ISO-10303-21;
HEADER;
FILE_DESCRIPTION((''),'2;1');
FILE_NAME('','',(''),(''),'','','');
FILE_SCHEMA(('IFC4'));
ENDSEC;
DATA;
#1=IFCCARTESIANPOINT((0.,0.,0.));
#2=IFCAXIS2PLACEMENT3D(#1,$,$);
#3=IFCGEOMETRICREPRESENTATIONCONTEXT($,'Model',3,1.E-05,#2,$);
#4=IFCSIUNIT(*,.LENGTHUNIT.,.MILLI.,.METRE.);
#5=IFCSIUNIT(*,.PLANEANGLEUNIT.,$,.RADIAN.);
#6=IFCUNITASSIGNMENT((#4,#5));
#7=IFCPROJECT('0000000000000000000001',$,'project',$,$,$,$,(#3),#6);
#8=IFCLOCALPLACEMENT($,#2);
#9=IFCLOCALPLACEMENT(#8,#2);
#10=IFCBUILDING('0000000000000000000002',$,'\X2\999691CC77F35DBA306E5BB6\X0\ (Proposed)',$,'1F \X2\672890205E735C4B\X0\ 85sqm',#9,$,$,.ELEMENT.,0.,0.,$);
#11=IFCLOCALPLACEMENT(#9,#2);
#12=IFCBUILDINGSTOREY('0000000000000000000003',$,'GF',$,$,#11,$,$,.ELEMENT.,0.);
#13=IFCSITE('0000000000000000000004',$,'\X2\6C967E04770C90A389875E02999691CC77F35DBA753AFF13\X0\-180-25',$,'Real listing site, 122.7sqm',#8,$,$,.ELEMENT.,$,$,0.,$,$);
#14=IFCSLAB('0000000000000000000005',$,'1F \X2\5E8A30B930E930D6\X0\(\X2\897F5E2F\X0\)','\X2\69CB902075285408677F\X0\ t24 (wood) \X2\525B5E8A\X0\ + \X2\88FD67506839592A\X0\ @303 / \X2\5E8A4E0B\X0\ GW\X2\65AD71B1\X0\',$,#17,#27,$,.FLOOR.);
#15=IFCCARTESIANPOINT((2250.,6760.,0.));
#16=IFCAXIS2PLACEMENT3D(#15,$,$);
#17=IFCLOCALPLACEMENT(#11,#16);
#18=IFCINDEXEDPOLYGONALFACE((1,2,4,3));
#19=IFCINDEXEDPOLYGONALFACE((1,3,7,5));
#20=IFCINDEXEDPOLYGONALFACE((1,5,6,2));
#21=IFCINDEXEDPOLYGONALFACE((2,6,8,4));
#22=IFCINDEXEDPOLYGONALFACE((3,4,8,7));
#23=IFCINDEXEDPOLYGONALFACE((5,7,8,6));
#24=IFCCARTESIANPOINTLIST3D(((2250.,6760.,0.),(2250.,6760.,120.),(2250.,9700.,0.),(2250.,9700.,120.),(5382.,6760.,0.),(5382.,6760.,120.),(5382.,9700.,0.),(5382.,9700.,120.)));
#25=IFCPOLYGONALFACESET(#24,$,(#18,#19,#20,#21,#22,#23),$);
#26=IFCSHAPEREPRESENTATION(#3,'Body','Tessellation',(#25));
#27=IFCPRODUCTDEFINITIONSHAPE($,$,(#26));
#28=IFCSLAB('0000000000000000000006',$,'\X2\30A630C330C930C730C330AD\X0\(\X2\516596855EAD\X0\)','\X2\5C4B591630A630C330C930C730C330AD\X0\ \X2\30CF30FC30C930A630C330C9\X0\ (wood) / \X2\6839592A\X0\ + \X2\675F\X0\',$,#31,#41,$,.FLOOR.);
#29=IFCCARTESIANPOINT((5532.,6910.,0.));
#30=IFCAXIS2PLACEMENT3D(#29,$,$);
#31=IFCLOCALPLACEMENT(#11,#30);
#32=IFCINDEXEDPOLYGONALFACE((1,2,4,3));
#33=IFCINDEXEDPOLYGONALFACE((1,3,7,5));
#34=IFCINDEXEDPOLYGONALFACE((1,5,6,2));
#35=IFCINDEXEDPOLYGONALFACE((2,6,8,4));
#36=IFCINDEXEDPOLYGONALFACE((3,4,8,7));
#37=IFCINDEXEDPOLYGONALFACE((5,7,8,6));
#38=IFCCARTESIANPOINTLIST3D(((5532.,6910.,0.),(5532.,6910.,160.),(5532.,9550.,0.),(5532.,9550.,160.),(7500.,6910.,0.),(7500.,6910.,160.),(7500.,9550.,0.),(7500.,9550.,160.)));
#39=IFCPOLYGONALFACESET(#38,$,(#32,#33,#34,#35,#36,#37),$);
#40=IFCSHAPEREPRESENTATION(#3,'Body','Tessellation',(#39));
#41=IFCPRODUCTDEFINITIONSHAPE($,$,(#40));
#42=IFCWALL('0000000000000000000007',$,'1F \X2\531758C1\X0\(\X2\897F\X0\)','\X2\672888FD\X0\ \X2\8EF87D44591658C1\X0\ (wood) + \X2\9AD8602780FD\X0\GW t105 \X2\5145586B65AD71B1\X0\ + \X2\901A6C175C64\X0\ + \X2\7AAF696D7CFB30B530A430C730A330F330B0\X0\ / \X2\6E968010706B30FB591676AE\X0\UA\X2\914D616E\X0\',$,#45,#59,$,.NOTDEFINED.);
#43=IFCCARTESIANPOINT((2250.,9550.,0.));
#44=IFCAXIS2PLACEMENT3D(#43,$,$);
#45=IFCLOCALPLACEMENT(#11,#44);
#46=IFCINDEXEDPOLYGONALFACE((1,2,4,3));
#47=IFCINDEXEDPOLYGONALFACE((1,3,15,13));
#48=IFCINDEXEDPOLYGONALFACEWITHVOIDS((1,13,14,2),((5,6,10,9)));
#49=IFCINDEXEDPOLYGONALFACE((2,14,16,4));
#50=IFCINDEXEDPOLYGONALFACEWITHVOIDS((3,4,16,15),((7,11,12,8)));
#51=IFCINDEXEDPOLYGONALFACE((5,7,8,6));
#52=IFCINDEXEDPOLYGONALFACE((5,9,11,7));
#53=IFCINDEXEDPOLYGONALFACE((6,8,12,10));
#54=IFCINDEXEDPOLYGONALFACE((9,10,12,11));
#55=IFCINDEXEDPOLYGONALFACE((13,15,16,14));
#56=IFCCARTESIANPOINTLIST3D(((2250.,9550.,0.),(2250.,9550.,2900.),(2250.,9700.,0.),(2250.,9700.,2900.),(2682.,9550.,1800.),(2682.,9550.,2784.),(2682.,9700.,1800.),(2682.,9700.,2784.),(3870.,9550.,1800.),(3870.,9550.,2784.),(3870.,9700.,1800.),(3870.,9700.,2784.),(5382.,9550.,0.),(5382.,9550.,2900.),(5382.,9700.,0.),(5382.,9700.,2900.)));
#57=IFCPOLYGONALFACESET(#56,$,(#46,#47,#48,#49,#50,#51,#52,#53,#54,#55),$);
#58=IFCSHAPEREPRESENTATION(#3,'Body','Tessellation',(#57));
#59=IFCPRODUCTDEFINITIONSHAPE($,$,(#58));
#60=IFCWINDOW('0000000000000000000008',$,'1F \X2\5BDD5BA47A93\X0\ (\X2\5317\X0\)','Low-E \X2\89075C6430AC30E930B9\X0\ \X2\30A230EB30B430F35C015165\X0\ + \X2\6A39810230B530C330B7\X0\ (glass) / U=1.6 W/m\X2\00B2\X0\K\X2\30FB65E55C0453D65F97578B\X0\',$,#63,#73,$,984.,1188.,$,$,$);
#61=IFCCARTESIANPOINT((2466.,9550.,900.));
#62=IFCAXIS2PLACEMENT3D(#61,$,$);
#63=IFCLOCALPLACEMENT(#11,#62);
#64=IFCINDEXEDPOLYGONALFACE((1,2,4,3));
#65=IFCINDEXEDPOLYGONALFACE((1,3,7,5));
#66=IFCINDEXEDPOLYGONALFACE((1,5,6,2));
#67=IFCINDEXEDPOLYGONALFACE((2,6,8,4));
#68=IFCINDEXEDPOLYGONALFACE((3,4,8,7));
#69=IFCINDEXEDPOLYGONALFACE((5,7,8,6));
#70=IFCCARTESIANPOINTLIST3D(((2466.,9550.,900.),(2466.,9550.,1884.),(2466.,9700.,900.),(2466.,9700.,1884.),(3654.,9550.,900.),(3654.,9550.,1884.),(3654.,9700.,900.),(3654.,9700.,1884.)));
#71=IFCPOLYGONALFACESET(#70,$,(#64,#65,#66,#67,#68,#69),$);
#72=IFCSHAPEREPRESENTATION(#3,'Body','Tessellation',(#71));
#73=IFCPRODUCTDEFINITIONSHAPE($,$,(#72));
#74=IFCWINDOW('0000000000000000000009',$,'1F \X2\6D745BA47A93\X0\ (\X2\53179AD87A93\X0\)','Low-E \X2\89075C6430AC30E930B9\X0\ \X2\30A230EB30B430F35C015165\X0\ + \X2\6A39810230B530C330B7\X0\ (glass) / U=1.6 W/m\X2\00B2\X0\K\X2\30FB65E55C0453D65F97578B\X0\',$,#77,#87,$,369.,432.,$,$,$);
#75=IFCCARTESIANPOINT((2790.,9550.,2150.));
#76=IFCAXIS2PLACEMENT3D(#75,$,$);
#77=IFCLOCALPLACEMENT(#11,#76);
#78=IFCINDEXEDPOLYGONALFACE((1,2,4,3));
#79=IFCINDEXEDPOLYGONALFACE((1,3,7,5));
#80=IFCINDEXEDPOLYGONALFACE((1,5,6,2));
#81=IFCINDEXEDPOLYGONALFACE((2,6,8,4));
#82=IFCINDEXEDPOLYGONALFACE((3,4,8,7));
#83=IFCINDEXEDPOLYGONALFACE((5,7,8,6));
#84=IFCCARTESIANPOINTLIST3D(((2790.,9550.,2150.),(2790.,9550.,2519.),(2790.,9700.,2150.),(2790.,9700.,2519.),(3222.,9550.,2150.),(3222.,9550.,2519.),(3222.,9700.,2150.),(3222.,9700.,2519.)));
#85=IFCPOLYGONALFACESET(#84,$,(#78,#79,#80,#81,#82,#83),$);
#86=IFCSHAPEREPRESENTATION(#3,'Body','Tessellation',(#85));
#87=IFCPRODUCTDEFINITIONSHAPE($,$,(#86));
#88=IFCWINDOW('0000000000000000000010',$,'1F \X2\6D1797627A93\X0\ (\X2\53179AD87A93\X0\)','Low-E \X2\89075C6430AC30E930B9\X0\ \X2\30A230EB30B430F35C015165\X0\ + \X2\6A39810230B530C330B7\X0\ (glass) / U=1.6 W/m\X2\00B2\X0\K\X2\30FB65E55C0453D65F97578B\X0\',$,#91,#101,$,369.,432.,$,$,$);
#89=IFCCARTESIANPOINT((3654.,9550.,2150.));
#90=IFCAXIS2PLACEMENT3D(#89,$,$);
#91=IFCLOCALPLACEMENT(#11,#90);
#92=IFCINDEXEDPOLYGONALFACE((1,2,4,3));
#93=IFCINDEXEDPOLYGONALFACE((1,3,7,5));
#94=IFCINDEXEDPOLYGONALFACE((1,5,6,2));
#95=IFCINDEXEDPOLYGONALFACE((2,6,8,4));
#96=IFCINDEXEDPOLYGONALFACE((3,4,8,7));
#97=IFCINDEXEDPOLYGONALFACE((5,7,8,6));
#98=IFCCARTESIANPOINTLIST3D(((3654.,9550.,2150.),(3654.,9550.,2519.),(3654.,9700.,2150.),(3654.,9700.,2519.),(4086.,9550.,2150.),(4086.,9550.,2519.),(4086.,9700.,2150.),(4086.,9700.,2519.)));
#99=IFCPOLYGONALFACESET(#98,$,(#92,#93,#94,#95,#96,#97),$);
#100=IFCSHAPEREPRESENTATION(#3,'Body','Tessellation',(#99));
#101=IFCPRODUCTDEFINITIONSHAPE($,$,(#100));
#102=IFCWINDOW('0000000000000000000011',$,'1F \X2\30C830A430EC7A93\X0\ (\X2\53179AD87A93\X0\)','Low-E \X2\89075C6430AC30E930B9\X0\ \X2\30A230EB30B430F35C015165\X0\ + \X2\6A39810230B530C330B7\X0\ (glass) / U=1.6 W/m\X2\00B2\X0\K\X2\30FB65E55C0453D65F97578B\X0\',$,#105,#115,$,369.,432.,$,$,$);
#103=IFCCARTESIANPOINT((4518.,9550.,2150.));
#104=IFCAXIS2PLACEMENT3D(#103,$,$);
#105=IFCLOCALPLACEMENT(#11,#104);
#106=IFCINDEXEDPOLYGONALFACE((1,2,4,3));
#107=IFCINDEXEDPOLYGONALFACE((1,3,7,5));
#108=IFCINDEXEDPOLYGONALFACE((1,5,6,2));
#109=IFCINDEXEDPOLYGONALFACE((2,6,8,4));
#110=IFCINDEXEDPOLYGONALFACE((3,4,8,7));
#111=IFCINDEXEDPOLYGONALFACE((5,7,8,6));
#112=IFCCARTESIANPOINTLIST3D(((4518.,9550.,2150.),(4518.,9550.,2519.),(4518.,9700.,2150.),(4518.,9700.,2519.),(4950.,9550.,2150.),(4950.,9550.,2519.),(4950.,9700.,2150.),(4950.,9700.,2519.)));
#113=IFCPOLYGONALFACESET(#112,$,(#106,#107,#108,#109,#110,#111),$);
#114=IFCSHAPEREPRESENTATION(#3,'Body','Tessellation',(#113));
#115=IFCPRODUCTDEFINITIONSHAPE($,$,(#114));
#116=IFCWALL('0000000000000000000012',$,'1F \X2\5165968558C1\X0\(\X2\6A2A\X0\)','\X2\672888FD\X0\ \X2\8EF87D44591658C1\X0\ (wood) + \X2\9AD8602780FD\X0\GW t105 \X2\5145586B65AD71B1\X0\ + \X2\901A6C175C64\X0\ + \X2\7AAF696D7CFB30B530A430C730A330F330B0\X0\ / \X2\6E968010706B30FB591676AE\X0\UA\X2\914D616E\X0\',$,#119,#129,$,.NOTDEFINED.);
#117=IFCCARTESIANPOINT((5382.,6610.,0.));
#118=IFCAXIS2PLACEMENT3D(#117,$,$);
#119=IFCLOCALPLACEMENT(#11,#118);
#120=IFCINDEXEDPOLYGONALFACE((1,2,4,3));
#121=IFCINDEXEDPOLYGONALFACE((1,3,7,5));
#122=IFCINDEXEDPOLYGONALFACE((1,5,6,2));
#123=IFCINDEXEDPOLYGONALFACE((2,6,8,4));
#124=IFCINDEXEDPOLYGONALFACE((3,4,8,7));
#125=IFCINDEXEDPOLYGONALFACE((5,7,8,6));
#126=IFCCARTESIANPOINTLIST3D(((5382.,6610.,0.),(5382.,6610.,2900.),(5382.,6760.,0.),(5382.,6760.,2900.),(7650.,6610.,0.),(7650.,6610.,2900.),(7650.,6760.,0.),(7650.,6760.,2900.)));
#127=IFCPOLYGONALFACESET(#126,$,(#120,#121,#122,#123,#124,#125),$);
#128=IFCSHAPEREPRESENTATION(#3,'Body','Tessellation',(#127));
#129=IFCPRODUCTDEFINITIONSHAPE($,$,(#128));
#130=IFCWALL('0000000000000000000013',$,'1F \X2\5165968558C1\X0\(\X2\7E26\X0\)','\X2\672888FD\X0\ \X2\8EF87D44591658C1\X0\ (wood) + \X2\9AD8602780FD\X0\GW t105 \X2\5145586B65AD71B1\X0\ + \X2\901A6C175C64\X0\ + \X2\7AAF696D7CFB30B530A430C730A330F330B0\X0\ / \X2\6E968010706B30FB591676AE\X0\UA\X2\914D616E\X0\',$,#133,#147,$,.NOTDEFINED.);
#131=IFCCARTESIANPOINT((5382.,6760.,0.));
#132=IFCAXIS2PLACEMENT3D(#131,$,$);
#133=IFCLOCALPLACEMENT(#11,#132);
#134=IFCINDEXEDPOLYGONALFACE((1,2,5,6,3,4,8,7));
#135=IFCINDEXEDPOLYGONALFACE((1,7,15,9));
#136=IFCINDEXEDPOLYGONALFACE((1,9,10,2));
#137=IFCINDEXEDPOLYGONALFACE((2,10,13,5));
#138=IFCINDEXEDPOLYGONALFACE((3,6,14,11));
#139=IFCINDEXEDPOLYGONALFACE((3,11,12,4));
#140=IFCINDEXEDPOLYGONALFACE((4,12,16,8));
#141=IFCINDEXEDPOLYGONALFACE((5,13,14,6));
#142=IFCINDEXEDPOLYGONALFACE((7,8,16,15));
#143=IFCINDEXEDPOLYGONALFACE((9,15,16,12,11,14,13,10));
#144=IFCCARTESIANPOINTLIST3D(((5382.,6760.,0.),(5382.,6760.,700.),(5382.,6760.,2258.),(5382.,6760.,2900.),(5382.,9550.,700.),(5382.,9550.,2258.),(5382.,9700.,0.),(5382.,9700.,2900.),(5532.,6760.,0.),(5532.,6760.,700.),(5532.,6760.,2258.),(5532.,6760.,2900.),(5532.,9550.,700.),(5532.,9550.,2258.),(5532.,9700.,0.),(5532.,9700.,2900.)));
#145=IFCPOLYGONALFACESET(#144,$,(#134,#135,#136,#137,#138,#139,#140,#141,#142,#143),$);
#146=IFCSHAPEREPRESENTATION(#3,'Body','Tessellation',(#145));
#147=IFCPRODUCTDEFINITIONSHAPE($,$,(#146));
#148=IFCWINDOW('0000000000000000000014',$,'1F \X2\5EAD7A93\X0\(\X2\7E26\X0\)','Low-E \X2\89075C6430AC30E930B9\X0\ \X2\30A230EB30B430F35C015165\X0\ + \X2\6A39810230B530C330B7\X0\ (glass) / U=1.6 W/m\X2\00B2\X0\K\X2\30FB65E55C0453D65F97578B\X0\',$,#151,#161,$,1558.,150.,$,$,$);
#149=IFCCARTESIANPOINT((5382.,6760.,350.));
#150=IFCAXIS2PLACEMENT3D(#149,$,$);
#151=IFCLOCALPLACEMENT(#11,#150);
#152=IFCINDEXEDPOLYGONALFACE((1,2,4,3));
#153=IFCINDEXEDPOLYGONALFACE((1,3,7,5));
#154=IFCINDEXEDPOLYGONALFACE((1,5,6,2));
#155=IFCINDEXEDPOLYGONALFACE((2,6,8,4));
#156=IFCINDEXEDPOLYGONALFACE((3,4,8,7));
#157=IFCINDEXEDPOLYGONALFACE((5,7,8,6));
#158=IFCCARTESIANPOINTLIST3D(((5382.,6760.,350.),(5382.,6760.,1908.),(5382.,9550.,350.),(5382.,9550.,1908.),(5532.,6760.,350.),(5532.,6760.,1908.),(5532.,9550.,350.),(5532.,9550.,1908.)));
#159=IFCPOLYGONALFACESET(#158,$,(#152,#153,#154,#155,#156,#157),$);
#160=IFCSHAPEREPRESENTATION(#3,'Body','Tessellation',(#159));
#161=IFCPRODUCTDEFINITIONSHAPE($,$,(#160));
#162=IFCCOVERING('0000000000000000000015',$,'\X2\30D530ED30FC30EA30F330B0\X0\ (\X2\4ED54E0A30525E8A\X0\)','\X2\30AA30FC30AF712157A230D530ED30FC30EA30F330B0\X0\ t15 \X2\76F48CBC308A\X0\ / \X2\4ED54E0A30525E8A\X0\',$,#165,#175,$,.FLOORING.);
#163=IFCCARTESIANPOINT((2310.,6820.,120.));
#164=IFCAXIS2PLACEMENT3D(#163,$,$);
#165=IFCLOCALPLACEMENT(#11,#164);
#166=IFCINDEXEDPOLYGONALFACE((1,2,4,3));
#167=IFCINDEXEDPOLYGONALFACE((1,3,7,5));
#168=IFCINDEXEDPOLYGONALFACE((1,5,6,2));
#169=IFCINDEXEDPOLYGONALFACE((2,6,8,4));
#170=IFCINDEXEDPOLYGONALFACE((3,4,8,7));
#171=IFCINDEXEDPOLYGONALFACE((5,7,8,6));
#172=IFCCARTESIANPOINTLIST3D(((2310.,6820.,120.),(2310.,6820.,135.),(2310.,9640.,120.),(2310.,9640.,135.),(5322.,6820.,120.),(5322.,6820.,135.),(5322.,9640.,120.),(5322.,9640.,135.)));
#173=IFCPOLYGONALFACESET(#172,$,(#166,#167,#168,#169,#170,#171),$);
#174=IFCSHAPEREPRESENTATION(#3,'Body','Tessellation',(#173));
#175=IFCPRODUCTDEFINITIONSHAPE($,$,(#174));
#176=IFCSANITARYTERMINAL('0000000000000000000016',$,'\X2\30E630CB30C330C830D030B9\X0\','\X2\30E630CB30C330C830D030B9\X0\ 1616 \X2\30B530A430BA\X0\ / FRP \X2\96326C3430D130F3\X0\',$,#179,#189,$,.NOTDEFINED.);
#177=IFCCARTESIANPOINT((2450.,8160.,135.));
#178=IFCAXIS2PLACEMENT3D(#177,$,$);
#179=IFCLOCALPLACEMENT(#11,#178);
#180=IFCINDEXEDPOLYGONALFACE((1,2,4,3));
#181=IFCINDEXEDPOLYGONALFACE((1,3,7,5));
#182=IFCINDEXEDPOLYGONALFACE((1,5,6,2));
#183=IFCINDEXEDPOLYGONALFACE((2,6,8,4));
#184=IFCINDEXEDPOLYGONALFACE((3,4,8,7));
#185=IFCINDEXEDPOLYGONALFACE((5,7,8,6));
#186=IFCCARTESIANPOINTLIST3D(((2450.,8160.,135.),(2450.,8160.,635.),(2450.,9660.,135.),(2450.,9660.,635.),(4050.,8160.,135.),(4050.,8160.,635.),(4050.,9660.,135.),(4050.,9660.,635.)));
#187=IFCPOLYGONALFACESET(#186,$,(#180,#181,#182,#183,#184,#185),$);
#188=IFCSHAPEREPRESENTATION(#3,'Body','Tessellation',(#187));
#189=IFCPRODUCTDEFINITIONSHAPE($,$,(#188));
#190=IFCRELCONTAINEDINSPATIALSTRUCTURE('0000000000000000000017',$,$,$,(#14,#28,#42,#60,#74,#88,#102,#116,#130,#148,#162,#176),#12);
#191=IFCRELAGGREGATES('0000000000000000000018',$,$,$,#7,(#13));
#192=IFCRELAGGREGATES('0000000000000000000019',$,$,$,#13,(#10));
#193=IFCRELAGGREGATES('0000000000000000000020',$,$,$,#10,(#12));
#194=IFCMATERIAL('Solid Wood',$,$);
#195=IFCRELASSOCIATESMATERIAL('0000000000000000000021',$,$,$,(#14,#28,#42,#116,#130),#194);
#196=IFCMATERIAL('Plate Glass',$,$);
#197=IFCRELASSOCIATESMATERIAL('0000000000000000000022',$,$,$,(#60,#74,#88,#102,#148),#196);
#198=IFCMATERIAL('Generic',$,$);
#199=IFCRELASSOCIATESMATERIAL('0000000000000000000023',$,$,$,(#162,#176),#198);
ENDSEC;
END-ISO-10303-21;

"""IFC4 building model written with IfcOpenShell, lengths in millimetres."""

from ifc_helpers import new_model, si_unit, frame, frame_2d, origin, place, context, project, spatial, rectangle, extrude, material, element, fill, save


model = new_model("IFC4")

# Units and contexts
model_context = context("Model", 3, precision=1e-05, world=origin())
ifc_project = project(units=[si_unit("LENGTHUNIT", "METRE", prefix="MILLI"), si_unit("PLANEANGLEUNIT", "RADIAN")], contexts=[model_context])

# Site, building, storey
site_placement = place(None, origin())
site = spatial("IfcSite", under=ifc_project, at=site_placement, Name="沖縄県那覇市首里石嶺町３-180-25", ObjectType="Real listing site, 122.7sqm", CompositionType="ELEMENT", RefElevation=0.0)
building_placement = place(site_placement, origin())
building = spatial("IfcBuilding", under=site, at=building_placement, Name="首里石嶺の家 (Proposed)", ObjectType="1F 木造平屋 85sqm", CompositionType="ELEMENT", ElevationOfRefHeight=0.0, ElevationOfTerrain=0.0)
storey_placement = place(building_placement, origin())
storey = spatial("IfcBuildingStorey", under=building, at=storey_placement, Name="GF", CompositionType="ELEMENT", Elevation=0.0)

# Slabs
ifc_material_1 = material(Name="Solid Wood")
slab_1_placement = place(storey_placement, frame((2250.0, 6760.0, 0.0)))
element("IfcSlab", 1, at=slab_1_placement, inside=storey, material=ifc_material_1, Name="1F 床スラブ(西帯)", Description="構造用合板 t24 (wood) 剛床 + 製材根太 @303 / 床下 GW断熱", PredefinedType="FLOOR", context=model_context, shape_type="SweptSolid", body=[
    extrude(rectangle(XDim=3132.0, YDim=2940.0, at=frame_2d((1566.0, 1470.0))), frame((2250.0, 6760.0, 0.0)), (0.0, 0.0, 1.0), 120.0),
])
slab_2_placement = place(storey_placement, frame((5532.0, 6910.0, 0.0)))
element("IfcSlab", 2, at=slab_2_placement, inside=storey, material=ifc_material_1, Name="ウッドデッキ(入隅庭)", Description="屋外ウッドデッキ ハードウッド (wood) / 根太 + 束", PredefinedType="FLOOR", context=model_context, shape_type="SweptSolid", body=[
    extrude(rectangle(XDim=1968.0, YDim=2640.0, at=frame_2d((984.0, 1320.0))), frame((5532.0, 6910.0, 0.0)), (0.0, 0.0, 1.0), 160.0),
])

# Wall, openings, windows
wall_1_placement = place(storey_placement, frame((2250.0, 9550.0, 0.0)))
wall_1 = element("IfcWall", 3, at=wall_1_placement, inside=storey, material=ifc_material_1, Name="1F 北壁(西)", Description="木製 軸組外壁 (wood) + 高性能GW t105 充填断熱 + 通気層 + 窯業系サイディング / 準耐火・外皮UA配慮", PredefinedType="NOTDEFINED", context=model_context, shape_type="SweptSolid", body=[
    extrude(rectangle(XDim=3132.0, YDim=150.0, at=frame_2d((1566.0, 75.0))), frame((2250.0, 9550.0, 0.0)), (0.0, 0.0, 1.0), 2900.0),
])
opening_1_placement = place(storey_placement, frame((2466.0, 9550.0, 900.0)))
opening_1 = element("IfcOpeningElement", 4, at=opening_1_placement, cuts=wall_1, PredefinedType="NOTDEFINED", context=model_context, shape_type="SweptSolid", body=[
    extrude(rectangle(XDim=1188.0, YDim=150.0, at=frame_2d((594.0, 75.0))), frame((2466.0, 9550.0, 900.0)), (0.0, 0.0, 1.0), 984.0),
])
opening_2_placement = place(storey_placement, frame((2790.0, 9550.0, 2150.0)))
opening_2 = element("IfcOpeningElement", 5, at=opening_2_placement, cuts=wall_1, PredefinedType="NOTDEFINED", context=model_context, shape_type="SweptSolid", body=[
    extrude(rectangle(XDim=432.0, YDim=150.0, at=frame_2d((216.0, 75.0))), frame((2790.0, 9550.0, 2150.0)), (0.0, 0.0, 1.0), 369.0),
])
opening_3_placement = place(storey_placement, frame((3654.0, 9550.0, 2150.0)))
opening_3 = element("IfcOpeningElement", 6, at=opening_3_placement, cuts=wall_1, PredefinedType="NOTDEFINED", context=model_context, shape_type="SweptSolid", body=[
    extrude(rectangle(XDim=432.0, YDim=150.0, at=frame_2d((216.0, 75.0))), frame((3654.0, 9550.0, 2150.0)), (0.0, 0.0, 1.0), 369.0),
])
opening_4_placement = place(storey_placement, frame((4518.0, 9550.0, 2150.0)))
opening_4 = element("IfcOpeningElement", 7, at=opening_4_placement, cuts=wall_1, PredefinedType="NOTDEFINED", context=model_context, shape_type="SweptSolid", body=[
    extrude(rectangle(XDim=432.0, YDim=150.0, at=frame_2d((216.0, 75.0))), frame((4518.0, 9550.0, 2150.0)), (0.0, 0.0, 1.0), 369.0),
])
ifc_material_2 = material(Name="Plate Glass")
window_1_placement = place(storey_placement, frame((2466.0, 9550.0, 900.0)))
window_1 = element("IfcWindow", 8, at=window_1_placement, inside=storey, material=ifc_material_2, Name="1F 寝室窓 (北)", Description="Low-E 複層ガラス アルゴン封入 + 樹脂サッシ (glass) / U=1.6 W/m²K・日射取得型", OverallHeight=984.0, OverallWidth=1188.0, context=model_context, shape_type="SweptSolid", body=[
    extrude(rectangle(XDim=1188.0, YDim=150.0, at=frame_2d((594.0, 75.0))), frame((2466.0, 9550.0, 900.0)), (0.0, 0.0, 1.0), 984.0),
])
fill(opening_1, window_1)
window_2_placement = place(storey_placement, frame((2790.0, 9550.0, 2150.0)))
window_2 = element("IfcWindow", 9, at=window_2_placement, inside=storey, material=ifc_material_2, Name="1F 浴室窓 (北高窓)", Description="Low-E 複層ガラス アルゴン封入 + 樹脂サッシ (glass) / U=1.6 W/m²K・日射取得型", OverallHeight=369.0, OverallWidth=432.0, context=model_context, shape_type="SweptSolid", body=[
    extrude(rectangle(XDim=432.0, YDim=150.0, at=frame_2d((216.0, 75.0))), frame((2790.0, 9550.0, 2150.0)), (0.0, 0.0, 1.0), 369.0),
])
fill(opening_2, window_2)
window_3_placement = place(storey_placement, frame((3654.0, 9550.0, 2150.0)))
window_3 = element("IfcWindow", 10, at=window_3_placement, inside=storey, material=ifc_material_2, Name="1F 洗面窓 (北高窓)", Description="Low-E 複層ガラス アルゴン封入 + 樹脂サッシ (glass) / U=1.6 W/m²K・日射取得型", OverallHeight=369.0, OverallWidth=432.0, context=model_context, shape_type="SweptSolid", body=[
    extrude(rectangle(XDim=432.0, YDim=150.0, at=frame_2d((216.0, 75.0))), frame((3654.0, 9550.0, 2150.0)), (0.0, 0.0, 1.0), 369.0),
])
fill(opening_3, window_3)
window_4_placement = place(storey_placement, frame((4518.0, 9550.0, 2150.0)))
window_4 = element("IfcWindow", 11, at=window_4_placement, inside=storey, material=ifc_material_2, Name="1F トイレ窓 (北高窓)", Description="Low-E 複層ガラス アルゴン封入 + 樹脂サッシ (glass) / U=1.6 W/m²K・日射取得型", OverallHeight=369.0, OverallWidth=432.0, context=model_context, shape_type="SweptSolid", body=[
    extrude(rectangle(XDim=432.0, YDim=150.0, at=frame_2d((216.0, 75.0))), frame((4518.0, 9550.0, 2150.0)), (0.0, 0.0, 1.0), 369.0),
])
fill(opening_4, window_4)

# Wall
wall_2_placement = place(storey_placement, frame((5382.0, 6610.0, 0.0)))
element("IfcWall", 12, at=wall_2_placement, inside=storey, material=ifc_material_1, Name="1F 入隅壁(横)", Description="木製 軸組外壁 (wood) + 高性能GW t105 充填断熱 + 通気層 + 窯業系サイディング / 準耐火・外皮UA配慮", PredefinedType="NOTDEFINED", context=model_context, shape_type="SweptSolid", body=[
    extrude(rectangle(XDim=2268.0, YDim=150.0, at=frame_2d((1134.0, 75.0))), frame((5382.0, 6610.0, 0.0)), (0.0, 0.0, 1.0), 2900.0),
])

# Wall, opening, window
wall_3_placement = place(storey_placement, frame((5382.0, 6760.0, 0.0)))
wall_3 = element("IfcWall", 13, at=wall_3_placement, inside=storey, material=ifc_material_1, Name="1F 入隅壁(縦)", Description="木製 軸組外壁 (wood) + 高性能GW t105 充填断熱 + 通気層 + 窯業系サイディング / 準耐火・外皮UA配慮", PredefinedType="NOTDEFINED", context=model_context, shape_type="SweptSolid", body=[
    extrude(rectangle(XDim=150.0, YDim=2940.0, at=frame_2d((75.0, 1470.0))), frame((5382.0, 6760.0, 0.0)), (0.0, 0.0, 1.0), 2900.0),
])
opening_5_placement = place(storey_placement, frame((5382.0, 6760.0, 350.0)))
opening_5 = element("IfcOpeningElement", 14, at=opening_5_placement, cuts=wall_3, PredefinedType="NOTDEFINED", context=model_context, shape_type="SweptSolid", body=[
    extrude(rectangle(XDim=150.0, YDim=2790.0, at=frame_2d((75.0, 1395.0))), frame((5382.0, 6760.0, 350.0)), (0.0, 0.0, 1.0), 1558.0),
])
window_5_placement = place(storey_placement, frame((5382.0, 6760.0, 350.0)))
window_5 = element("IfcWindow", 15, at=window_5_placement, inside=storey, material=ifc_material_2, Name="1F 庭窓(縦)", Description="Low-E 複層ガラス アルゴン封入 + 樹脂サッシ (glass) / U=1.6 W/m²K・日射取得型", OverallHeight=1558.0, OverallWidth=150.0, context=model_context, shape_type="SweptSolid", body=[
    extrude(rectangle(XDim=150.0, YDim=2790.0, at=frame_2d((75.0, 1395.0))), frame((5382.0, 6760.0, 350.0)), (0.0, 0.0, 1.0), 1558.0),
])
fill(opening_5, window_5)

# Covering
ifc_material_3 = material(Name="Generic")
covering_placement = place(storey_placement, frame((2310.0, 6820.0, 120.0)))
element("IfcCovering", 16, at=covering_placement, inside=storey, material=ifc_material_3, Name="フローリング (仕上げ床)", Description="オーク無垢フローリング t15 直貼り / 仕上げ床", PredefinedType="FLOORING", context=model_context, shape_type="SweptSolid", body=[
    extrude(rectangle(XDim=3012.0, YDim=2820.0, at=frame_2d((1506.0, 1410.0))), frame((2310.0, 6820.0, 120.0)), (0.0, 0.0, 1.0), 15.0),
])

# Sanitary terminal
sanitary_terminal_1_placement = place(storey_placement, frame((2450.0, 8160.0, 135.0)))
element("IfcSanitaryTerminal", 17, at=sanitary_terminal_1_placement, inside=storey, material=ifc_material_3, Name="ユニットバス", Description="ユニットバス 1616 サイズ / FRP 防水パン", PredefinedType="NOTDEFINED", context=model_context, shape_type="SweptSolid", body=[
    extrude(rectangle(XDim=1600.0, YDim=1500.0, at=frame_2d((800.0, 750.0))), frame((2450.0, 8160.0, 135.0)), (0.0, 0.0, 1.0), 500.0),
])

save(model, "model.ifc")
